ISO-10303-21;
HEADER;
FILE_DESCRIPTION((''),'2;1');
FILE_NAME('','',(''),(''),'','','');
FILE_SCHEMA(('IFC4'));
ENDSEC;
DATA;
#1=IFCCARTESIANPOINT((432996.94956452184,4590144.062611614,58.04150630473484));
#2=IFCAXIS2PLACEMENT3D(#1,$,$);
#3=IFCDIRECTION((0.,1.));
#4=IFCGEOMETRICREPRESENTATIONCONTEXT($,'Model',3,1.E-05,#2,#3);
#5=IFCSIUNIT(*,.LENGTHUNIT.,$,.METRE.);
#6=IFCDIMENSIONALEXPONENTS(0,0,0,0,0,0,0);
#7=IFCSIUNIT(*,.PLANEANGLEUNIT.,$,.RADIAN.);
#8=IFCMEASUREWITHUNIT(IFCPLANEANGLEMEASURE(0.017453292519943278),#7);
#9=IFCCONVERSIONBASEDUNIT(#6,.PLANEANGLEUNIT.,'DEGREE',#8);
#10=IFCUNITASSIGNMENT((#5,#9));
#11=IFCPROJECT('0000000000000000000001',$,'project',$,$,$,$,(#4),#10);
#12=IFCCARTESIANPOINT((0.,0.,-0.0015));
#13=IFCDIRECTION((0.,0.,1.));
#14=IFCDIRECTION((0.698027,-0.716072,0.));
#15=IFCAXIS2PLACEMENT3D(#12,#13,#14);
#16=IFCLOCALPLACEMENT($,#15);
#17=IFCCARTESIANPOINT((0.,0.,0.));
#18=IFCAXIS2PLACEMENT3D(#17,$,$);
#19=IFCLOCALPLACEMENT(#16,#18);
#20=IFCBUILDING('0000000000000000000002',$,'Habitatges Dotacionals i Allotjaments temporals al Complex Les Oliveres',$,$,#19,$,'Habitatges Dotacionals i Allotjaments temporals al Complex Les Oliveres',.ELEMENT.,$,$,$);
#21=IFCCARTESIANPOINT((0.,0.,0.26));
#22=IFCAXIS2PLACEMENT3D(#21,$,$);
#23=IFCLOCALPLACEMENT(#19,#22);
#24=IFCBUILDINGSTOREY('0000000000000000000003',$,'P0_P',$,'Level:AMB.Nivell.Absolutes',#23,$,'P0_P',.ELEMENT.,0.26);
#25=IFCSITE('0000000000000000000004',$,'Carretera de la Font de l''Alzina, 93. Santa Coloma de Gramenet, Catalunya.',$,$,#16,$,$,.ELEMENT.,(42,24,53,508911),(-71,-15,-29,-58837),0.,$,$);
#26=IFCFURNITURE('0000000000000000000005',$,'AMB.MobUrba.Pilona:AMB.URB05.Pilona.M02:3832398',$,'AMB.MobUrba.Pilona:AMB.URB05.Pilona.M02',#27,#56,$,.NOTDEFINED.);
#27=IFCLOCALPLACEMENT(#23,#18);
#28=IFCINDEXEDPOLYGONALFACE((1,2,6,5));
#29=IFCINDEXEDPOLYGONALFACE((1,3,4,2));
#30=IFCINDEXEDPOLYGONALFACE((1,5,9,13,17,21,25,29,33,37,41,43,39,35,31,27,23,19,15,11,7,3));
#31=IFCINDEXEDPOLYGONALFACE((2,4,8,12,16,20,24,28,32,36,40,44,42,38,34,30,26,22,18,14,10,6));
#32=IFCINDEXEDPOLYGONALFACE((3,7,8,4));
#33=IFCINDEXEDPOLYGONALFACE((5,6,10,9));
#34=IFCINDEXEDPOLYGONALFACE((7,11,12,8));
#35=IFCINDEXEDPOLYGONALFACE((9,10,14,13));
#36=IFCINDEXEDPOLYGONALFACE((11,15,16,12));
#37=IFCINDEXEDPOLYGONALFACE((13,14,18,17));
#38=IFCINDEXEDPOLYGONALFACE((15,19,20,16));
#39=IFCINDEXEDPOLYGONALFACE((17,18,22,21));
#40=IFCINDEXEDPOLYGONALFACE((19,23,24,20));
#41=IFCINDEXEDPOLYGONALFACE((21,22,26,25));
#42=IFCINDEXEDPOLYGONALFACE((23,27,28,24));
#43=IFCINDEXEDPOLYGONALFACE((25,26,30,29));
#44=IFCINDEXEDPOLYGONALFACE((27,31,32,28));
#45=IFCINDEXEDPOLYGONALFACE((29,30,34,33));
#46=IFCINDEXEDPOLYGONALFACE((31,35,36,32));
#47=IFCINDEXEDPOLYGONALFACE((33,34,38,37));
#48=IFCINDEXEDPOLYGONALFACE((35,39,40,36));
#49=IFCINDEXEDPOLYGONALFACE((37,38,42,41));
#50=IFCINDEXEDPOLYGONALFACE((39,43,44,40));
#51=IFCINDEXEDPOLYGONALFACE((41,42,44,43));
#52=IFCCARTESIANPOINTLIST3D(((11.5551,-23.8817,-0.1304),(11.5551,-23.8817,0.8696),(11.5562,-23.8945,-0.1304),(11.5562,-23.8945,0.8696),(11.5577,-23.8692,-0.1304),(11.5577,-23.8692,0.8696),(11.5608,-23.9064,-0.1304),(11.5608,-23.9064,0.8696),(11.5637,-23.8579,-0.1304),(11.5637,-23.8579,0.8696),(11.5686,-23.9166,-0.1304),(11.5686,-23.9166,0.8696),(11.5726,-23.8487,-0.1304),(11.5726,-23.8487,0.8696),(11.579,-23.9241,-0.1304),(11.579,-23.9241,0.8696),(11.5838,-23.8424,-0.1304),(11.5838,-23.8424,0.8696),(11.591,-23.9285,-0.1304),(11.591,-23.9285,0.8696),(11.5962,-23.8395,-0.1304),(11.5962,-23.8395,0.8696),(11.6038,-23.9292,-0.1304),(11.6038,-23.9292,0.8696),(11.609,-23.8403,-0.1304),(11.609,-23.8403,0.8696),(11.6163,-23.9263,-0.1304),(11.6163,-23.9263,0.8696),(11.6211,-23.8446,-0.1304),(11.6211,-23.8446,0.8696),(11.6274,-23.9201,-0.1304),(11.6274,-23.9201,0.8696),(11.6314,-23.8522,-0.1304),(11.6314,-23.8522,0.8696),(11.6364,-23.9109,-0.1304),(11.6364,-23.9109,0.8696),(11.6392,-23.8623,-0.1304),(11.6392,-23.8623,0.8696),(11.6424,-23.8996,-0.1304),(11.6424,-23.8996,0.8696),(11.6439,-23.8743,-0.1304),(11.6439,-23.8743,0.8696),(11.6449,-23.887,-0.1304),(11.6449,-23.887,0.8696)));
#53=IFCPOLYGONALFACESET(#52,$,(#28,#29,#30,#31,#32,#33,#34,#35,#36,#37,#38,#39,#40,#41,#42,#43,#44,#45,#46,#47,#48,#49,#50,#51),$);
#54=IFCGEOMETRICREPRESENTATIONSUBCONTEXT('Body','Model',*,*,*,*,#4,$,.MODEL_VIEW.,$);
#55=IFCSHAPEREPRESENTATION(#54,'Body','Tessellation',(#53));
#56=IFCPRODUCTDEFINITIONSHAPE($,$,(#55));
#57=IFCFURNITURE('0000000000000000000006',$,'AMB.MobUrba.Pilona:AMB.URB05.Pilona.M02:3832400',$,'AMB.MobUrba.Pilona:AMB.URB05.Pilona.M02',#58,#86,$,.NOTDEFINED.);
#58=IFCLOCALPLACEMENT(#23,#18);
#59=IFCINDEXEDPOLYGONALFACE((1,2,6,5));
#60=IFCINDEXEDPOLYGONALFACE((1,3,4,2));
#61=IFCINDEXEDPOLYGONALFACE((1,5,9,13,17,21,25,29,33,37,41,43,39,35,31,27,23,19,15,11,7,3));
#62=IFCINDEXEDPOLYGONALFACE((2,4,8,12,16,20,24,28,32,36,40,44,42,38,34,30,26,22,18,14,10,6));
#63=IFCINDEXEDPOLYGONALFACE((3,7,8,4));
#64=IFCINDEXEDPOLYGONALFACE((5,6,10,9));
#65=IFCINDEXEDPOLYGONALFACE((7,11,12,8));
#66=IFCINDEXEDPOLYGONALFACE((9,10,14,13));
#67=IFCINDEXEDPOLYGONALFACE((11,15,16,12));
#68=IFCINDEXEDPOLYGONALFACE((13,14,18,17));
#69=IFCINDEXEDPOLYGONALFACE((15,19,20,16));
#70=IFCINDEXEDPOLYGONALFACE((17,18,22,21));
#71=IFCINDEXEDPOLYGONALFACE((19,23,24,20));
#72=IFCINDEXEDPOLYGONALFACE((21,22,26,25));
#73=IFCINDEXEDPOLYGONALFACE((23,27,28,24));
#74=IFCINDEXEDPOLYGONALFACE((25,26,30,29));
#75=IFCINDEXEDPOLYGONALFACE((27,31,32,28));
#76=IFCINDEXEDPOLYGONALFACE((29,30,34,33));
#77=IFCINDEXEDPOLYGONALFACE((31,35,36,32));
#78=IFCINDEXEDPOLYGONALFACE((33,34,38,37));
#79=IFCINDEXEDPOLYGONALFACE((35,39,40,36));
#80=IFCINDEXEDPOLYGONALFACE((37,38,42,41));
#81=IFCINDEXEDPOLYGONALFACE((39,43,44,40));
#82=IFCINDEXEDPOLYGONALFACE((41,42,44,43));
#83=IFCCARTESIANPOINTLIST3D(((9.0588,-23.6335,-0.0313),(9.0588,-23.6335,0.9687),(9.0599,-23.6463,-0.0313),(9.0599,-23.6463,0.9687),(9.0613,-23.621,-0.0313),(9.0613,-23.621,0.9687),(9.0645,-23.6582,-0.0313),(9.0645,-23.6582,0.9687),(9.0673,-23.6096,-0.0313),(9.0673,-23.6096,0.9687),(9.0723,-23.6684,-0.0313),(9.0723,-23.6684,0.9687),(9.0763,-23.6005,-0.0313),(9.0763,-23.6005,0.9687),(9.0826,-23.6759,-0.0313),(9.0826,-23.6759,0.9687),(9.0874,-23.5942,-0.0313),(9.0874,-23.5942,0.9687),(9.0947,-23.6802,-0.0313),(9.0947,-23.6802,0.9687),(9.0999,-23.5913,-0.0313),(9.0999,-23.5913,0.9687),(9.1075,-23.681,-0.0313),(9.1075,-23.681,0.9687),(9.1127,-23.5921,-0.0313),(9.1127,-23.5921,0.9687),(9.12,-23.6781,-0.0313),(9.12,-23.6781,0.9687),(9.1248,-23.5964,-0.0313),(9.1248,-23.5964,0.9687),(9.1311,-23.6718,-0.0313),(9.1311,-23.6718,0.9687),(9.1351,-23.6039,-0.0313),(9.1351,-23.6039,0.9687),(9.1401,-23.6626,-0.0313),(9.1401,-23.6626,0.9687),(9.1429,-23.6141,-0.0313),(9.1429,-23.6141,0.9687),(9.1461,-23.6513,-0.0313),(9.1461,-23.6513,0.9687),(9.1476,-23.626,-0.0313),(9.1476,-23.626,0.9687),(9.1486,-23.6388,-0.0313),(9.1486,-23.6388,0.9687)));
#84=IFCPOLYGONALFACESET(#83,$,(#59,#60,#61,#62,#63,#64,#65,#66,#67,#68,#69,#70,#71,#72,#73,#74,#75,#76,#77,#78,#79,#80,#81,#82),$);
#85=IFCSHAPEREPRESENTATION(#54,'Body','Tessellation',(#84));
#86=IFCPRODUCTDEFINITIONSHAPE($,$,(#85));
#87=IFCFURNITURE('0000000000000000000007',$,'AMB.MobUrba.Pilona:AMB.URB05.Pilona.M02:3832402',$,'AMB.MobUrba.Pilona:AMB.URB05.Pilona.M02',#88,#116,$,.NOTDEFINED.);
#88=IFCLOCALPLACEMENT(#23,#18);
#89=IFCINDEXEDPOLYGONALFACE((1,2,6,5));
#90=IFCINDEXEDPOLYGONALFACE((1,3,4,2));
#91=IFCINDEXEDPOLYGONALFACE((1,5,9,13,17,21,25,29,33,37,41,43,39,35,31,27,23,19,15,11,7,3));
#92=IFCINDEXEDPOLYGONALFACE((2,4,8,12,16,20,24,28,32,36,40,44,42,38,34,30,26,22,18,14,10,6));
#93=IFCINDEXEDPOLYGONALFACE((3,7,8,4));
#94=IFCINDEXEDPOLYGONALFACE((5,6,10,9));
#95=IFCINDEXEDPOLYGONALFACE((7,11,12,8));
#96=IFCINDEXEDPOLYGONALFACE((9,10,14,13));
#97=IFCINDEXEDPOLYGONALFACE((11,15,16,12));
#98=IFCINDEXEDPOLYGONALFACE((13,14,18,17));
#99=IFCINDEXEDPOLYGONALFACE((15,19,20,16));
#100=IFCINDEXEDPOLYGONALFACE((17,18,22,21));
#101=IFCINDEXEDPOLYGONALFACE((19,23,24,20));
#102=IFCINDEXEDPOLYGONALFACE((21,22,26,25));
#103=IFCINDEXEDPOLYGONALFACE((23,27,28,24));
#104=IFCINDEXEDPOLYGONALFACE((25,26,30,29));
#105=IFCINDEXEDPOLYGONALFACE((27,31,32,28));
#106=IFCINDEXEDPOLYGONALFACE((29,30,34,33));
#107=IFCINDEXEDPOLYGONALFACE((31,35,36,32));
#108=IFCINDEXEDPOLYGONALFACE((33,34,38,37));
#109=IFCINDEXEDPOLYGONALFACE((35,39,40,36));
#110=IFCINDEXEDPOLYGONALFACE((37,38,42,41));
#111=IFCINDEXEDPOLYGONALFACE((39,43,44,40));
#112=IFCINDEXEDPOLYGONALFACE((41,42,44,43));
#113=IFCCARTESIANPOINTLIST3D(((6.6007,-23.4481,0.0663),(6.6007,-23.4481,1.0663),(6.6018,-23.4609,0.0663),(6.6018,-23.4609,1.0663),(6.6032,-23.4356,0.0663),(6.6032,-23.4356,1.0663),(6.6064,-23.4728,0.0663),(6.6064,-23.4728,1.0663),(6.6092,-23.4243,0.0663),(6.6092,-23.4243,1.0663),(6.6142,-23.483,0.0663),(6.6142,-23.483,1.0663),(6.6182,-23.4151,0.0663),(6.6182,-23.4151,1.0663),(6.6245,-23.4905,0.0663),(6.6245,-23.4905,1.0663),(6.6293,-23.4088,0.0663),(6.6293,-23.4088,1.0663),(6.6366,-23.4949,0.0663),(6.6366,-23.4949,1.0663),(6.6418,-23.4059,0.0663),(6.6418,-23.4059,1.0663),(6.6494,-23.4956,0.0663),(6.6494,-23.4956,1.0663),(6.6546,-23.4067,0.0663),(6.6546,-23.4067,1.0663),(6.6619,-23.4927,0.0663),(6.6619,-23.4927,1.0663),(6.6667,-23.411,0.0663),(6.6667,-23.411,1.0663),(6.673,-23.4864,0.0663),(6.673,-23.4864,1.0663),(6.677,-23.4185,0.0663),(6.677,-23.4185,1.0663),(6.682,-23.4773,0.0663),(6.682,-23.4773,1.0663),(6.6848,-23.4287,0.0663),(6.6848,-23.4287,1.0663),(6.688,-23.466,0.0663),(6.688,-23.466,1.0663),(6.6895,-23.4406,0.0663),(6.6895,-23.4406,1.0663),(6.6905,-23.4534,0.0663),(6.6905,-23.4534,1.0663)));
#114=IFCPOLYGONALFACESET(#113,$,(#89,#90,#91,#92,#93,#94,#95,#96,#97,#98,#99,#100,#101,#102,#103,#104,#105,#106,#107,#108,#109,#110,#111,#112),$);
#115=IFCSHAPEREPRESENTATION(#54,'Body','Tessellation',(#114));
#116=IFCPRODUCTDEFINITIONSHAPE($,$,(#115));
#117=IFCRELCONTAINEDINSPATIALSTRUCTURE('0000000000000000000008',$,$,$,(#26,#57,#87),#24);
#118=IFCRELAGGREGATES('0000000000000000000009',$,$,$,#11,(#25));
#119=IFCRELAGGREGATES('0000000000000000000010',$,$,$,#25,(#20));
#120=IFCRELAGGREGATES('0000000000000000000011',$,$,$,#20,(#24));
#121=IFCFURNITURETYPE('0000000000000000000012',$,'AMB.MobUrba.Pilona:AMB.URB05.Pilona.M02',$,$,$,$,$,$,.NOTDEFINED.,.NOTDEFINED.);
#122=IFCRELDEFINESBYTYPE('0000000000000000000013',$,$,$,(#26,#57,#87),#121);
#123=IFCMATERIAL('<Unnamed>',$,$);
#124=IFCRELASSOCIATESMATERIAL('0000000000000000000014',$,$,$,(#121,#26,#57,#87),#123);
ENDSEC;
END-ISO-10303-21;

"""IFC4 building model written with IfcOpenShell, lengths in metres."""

from ifc_helpers import new_model, entity, si_unit, converted_unit, direction, frame, origin, place, context, subcontext, project, spatial, arc, indexed_curve, outline, extrude, source, transform, mapped, material, type_object, type_shapes, element, save


model = new_model("IFC4")

# Units and contexts
model_context = context("Model", 3, precision=1e-05, world=frame((432996.94956452184, 4590144.062611614, 58.04150630473484)), true_north=direction((0.0, 1.0)))
body_context = subcontext(model_context, "Body", "Model", "MODEL_VIEW")
ifc_project = project(units=[si_unit("LENGTHUNIT", "METRE"), converted_unit("PLANEANGLEUNIT", "DEGREE", entity("IfcPlaneAngleMeasure", 0.017453292519943278), si_unit("PLANEANGLEUNIT", "RADIAN"), dimensions=[0, 0, 0, 0, 0, 0, 0])], contexts=[model_context])

# Site, building, storey
site_placement = place(None, frame((0.0, 0.0, -0.0015), z_axis=(0.0, 0.0, 1.0), x_axis=(0.698027, -0.716072, 0.0)))
site = spatial("IfcSite", under=ifc_project, at=site_placement, Name="Carretera de la Font de l'Alzina, 93. Santa Coloma de Gramenet, Catalunya.", CompositionType="ELEMENT", RefLatitude=(42, 24, 53, 508911), RefLongitude=(-71, -15, -29, -58837), RefElevation=0.0)
building_placement = place(site_placement, origin())
building = spatial("IfcBuilding", under=site, at=building_placement, Name="Habitatges Dotacionals i Allotjaments temporals al Complex Les Oliveres", LongName="Habitatges Dotacionals i Allotjaments temporals al Complex Les Oliveres", CompositionType="ELEMENT")
storey_placement = place(building_placement, frame((0.0, 0.0, 0.26)))
storey = spatial("IfcBuildingStorey", under=building, at=storey_placement, Name="P0_P", ObjectType="Level:AMB.Nivell.Absolutes", LongName="P0_P", CompositionType="ELEMENT", Elevation=0.26)

# Furniture
ifc_material_1 = material(Name="<Unnamed>")
furniture_type = type_object("IfcFurnitureType", Name="AMB.MobUrba.Pilona:AMB.URB05.Pilona.M02", AssemblyPlace="NOTDEFINED", PredefinedType="NOTDEFINED", material=ifc_material_1)
shared_shape_1 = source(origin(), body_context, "Body", "SweptSolid", [
    extrude(outline(indexed_curve([(-0.045, 0.0), (0.0, -0.045), (0.045, 0.0), (0.0, 0.045)], segments=[arc(1, 2, 3), arc(3, 4, 1)], self_intersect=False)), frame((0.0012, -0.075, 0.0)), (0.0, 0.0, 1.0), 1.0),
])
type_shapes(furniture_type, [shared_shape_1])
for number, where, z_axis, x_axis, name in (
    (1, (11.5455, -23.8329, -0.1304), (0.0, 0.0, 1.0), (0.698027, 0.716072, 0.0), "AMB.MobUrba.Pilona:AMB.URB05.Pilona.M02:3832398"),
    (2, (9.0492, -23.5846, -0.0313), (0.0, 0.0, 1.0), (0.698027, 0.716072, 0.0), "AMB.MobUrba.Pilona:AMB.URB05.Pilona.M02:3832400"),
    (3, (6.5911, -23.3993, 0.0663), (0.0, 0.0, 1.0), (0.698027, 0.716072, 0.0), "AMB.MobUrba.Pilona:AMB.URB05.Pilona.M02:3832402"),
):
    element("IfcFurniture", number, at=place(storey_placement, frame(where, z_axis=z_axis, x_axis=x_axis)), inside=storey, type_object=furniture_type, material=ifc_material_1, Name=name, ObjectType="AMB.MobUrba.Pilona:AMB.URB05.Pilona.M02", PredefinedType="NOTDEFINED", context=body_context, shape_type="MappedRepresentation", body=[
        mapped(shared_shape_1, transform((0.0, 0.0, 0.0), scale=1.0)),
    ])

save(model, "model.ifc")
